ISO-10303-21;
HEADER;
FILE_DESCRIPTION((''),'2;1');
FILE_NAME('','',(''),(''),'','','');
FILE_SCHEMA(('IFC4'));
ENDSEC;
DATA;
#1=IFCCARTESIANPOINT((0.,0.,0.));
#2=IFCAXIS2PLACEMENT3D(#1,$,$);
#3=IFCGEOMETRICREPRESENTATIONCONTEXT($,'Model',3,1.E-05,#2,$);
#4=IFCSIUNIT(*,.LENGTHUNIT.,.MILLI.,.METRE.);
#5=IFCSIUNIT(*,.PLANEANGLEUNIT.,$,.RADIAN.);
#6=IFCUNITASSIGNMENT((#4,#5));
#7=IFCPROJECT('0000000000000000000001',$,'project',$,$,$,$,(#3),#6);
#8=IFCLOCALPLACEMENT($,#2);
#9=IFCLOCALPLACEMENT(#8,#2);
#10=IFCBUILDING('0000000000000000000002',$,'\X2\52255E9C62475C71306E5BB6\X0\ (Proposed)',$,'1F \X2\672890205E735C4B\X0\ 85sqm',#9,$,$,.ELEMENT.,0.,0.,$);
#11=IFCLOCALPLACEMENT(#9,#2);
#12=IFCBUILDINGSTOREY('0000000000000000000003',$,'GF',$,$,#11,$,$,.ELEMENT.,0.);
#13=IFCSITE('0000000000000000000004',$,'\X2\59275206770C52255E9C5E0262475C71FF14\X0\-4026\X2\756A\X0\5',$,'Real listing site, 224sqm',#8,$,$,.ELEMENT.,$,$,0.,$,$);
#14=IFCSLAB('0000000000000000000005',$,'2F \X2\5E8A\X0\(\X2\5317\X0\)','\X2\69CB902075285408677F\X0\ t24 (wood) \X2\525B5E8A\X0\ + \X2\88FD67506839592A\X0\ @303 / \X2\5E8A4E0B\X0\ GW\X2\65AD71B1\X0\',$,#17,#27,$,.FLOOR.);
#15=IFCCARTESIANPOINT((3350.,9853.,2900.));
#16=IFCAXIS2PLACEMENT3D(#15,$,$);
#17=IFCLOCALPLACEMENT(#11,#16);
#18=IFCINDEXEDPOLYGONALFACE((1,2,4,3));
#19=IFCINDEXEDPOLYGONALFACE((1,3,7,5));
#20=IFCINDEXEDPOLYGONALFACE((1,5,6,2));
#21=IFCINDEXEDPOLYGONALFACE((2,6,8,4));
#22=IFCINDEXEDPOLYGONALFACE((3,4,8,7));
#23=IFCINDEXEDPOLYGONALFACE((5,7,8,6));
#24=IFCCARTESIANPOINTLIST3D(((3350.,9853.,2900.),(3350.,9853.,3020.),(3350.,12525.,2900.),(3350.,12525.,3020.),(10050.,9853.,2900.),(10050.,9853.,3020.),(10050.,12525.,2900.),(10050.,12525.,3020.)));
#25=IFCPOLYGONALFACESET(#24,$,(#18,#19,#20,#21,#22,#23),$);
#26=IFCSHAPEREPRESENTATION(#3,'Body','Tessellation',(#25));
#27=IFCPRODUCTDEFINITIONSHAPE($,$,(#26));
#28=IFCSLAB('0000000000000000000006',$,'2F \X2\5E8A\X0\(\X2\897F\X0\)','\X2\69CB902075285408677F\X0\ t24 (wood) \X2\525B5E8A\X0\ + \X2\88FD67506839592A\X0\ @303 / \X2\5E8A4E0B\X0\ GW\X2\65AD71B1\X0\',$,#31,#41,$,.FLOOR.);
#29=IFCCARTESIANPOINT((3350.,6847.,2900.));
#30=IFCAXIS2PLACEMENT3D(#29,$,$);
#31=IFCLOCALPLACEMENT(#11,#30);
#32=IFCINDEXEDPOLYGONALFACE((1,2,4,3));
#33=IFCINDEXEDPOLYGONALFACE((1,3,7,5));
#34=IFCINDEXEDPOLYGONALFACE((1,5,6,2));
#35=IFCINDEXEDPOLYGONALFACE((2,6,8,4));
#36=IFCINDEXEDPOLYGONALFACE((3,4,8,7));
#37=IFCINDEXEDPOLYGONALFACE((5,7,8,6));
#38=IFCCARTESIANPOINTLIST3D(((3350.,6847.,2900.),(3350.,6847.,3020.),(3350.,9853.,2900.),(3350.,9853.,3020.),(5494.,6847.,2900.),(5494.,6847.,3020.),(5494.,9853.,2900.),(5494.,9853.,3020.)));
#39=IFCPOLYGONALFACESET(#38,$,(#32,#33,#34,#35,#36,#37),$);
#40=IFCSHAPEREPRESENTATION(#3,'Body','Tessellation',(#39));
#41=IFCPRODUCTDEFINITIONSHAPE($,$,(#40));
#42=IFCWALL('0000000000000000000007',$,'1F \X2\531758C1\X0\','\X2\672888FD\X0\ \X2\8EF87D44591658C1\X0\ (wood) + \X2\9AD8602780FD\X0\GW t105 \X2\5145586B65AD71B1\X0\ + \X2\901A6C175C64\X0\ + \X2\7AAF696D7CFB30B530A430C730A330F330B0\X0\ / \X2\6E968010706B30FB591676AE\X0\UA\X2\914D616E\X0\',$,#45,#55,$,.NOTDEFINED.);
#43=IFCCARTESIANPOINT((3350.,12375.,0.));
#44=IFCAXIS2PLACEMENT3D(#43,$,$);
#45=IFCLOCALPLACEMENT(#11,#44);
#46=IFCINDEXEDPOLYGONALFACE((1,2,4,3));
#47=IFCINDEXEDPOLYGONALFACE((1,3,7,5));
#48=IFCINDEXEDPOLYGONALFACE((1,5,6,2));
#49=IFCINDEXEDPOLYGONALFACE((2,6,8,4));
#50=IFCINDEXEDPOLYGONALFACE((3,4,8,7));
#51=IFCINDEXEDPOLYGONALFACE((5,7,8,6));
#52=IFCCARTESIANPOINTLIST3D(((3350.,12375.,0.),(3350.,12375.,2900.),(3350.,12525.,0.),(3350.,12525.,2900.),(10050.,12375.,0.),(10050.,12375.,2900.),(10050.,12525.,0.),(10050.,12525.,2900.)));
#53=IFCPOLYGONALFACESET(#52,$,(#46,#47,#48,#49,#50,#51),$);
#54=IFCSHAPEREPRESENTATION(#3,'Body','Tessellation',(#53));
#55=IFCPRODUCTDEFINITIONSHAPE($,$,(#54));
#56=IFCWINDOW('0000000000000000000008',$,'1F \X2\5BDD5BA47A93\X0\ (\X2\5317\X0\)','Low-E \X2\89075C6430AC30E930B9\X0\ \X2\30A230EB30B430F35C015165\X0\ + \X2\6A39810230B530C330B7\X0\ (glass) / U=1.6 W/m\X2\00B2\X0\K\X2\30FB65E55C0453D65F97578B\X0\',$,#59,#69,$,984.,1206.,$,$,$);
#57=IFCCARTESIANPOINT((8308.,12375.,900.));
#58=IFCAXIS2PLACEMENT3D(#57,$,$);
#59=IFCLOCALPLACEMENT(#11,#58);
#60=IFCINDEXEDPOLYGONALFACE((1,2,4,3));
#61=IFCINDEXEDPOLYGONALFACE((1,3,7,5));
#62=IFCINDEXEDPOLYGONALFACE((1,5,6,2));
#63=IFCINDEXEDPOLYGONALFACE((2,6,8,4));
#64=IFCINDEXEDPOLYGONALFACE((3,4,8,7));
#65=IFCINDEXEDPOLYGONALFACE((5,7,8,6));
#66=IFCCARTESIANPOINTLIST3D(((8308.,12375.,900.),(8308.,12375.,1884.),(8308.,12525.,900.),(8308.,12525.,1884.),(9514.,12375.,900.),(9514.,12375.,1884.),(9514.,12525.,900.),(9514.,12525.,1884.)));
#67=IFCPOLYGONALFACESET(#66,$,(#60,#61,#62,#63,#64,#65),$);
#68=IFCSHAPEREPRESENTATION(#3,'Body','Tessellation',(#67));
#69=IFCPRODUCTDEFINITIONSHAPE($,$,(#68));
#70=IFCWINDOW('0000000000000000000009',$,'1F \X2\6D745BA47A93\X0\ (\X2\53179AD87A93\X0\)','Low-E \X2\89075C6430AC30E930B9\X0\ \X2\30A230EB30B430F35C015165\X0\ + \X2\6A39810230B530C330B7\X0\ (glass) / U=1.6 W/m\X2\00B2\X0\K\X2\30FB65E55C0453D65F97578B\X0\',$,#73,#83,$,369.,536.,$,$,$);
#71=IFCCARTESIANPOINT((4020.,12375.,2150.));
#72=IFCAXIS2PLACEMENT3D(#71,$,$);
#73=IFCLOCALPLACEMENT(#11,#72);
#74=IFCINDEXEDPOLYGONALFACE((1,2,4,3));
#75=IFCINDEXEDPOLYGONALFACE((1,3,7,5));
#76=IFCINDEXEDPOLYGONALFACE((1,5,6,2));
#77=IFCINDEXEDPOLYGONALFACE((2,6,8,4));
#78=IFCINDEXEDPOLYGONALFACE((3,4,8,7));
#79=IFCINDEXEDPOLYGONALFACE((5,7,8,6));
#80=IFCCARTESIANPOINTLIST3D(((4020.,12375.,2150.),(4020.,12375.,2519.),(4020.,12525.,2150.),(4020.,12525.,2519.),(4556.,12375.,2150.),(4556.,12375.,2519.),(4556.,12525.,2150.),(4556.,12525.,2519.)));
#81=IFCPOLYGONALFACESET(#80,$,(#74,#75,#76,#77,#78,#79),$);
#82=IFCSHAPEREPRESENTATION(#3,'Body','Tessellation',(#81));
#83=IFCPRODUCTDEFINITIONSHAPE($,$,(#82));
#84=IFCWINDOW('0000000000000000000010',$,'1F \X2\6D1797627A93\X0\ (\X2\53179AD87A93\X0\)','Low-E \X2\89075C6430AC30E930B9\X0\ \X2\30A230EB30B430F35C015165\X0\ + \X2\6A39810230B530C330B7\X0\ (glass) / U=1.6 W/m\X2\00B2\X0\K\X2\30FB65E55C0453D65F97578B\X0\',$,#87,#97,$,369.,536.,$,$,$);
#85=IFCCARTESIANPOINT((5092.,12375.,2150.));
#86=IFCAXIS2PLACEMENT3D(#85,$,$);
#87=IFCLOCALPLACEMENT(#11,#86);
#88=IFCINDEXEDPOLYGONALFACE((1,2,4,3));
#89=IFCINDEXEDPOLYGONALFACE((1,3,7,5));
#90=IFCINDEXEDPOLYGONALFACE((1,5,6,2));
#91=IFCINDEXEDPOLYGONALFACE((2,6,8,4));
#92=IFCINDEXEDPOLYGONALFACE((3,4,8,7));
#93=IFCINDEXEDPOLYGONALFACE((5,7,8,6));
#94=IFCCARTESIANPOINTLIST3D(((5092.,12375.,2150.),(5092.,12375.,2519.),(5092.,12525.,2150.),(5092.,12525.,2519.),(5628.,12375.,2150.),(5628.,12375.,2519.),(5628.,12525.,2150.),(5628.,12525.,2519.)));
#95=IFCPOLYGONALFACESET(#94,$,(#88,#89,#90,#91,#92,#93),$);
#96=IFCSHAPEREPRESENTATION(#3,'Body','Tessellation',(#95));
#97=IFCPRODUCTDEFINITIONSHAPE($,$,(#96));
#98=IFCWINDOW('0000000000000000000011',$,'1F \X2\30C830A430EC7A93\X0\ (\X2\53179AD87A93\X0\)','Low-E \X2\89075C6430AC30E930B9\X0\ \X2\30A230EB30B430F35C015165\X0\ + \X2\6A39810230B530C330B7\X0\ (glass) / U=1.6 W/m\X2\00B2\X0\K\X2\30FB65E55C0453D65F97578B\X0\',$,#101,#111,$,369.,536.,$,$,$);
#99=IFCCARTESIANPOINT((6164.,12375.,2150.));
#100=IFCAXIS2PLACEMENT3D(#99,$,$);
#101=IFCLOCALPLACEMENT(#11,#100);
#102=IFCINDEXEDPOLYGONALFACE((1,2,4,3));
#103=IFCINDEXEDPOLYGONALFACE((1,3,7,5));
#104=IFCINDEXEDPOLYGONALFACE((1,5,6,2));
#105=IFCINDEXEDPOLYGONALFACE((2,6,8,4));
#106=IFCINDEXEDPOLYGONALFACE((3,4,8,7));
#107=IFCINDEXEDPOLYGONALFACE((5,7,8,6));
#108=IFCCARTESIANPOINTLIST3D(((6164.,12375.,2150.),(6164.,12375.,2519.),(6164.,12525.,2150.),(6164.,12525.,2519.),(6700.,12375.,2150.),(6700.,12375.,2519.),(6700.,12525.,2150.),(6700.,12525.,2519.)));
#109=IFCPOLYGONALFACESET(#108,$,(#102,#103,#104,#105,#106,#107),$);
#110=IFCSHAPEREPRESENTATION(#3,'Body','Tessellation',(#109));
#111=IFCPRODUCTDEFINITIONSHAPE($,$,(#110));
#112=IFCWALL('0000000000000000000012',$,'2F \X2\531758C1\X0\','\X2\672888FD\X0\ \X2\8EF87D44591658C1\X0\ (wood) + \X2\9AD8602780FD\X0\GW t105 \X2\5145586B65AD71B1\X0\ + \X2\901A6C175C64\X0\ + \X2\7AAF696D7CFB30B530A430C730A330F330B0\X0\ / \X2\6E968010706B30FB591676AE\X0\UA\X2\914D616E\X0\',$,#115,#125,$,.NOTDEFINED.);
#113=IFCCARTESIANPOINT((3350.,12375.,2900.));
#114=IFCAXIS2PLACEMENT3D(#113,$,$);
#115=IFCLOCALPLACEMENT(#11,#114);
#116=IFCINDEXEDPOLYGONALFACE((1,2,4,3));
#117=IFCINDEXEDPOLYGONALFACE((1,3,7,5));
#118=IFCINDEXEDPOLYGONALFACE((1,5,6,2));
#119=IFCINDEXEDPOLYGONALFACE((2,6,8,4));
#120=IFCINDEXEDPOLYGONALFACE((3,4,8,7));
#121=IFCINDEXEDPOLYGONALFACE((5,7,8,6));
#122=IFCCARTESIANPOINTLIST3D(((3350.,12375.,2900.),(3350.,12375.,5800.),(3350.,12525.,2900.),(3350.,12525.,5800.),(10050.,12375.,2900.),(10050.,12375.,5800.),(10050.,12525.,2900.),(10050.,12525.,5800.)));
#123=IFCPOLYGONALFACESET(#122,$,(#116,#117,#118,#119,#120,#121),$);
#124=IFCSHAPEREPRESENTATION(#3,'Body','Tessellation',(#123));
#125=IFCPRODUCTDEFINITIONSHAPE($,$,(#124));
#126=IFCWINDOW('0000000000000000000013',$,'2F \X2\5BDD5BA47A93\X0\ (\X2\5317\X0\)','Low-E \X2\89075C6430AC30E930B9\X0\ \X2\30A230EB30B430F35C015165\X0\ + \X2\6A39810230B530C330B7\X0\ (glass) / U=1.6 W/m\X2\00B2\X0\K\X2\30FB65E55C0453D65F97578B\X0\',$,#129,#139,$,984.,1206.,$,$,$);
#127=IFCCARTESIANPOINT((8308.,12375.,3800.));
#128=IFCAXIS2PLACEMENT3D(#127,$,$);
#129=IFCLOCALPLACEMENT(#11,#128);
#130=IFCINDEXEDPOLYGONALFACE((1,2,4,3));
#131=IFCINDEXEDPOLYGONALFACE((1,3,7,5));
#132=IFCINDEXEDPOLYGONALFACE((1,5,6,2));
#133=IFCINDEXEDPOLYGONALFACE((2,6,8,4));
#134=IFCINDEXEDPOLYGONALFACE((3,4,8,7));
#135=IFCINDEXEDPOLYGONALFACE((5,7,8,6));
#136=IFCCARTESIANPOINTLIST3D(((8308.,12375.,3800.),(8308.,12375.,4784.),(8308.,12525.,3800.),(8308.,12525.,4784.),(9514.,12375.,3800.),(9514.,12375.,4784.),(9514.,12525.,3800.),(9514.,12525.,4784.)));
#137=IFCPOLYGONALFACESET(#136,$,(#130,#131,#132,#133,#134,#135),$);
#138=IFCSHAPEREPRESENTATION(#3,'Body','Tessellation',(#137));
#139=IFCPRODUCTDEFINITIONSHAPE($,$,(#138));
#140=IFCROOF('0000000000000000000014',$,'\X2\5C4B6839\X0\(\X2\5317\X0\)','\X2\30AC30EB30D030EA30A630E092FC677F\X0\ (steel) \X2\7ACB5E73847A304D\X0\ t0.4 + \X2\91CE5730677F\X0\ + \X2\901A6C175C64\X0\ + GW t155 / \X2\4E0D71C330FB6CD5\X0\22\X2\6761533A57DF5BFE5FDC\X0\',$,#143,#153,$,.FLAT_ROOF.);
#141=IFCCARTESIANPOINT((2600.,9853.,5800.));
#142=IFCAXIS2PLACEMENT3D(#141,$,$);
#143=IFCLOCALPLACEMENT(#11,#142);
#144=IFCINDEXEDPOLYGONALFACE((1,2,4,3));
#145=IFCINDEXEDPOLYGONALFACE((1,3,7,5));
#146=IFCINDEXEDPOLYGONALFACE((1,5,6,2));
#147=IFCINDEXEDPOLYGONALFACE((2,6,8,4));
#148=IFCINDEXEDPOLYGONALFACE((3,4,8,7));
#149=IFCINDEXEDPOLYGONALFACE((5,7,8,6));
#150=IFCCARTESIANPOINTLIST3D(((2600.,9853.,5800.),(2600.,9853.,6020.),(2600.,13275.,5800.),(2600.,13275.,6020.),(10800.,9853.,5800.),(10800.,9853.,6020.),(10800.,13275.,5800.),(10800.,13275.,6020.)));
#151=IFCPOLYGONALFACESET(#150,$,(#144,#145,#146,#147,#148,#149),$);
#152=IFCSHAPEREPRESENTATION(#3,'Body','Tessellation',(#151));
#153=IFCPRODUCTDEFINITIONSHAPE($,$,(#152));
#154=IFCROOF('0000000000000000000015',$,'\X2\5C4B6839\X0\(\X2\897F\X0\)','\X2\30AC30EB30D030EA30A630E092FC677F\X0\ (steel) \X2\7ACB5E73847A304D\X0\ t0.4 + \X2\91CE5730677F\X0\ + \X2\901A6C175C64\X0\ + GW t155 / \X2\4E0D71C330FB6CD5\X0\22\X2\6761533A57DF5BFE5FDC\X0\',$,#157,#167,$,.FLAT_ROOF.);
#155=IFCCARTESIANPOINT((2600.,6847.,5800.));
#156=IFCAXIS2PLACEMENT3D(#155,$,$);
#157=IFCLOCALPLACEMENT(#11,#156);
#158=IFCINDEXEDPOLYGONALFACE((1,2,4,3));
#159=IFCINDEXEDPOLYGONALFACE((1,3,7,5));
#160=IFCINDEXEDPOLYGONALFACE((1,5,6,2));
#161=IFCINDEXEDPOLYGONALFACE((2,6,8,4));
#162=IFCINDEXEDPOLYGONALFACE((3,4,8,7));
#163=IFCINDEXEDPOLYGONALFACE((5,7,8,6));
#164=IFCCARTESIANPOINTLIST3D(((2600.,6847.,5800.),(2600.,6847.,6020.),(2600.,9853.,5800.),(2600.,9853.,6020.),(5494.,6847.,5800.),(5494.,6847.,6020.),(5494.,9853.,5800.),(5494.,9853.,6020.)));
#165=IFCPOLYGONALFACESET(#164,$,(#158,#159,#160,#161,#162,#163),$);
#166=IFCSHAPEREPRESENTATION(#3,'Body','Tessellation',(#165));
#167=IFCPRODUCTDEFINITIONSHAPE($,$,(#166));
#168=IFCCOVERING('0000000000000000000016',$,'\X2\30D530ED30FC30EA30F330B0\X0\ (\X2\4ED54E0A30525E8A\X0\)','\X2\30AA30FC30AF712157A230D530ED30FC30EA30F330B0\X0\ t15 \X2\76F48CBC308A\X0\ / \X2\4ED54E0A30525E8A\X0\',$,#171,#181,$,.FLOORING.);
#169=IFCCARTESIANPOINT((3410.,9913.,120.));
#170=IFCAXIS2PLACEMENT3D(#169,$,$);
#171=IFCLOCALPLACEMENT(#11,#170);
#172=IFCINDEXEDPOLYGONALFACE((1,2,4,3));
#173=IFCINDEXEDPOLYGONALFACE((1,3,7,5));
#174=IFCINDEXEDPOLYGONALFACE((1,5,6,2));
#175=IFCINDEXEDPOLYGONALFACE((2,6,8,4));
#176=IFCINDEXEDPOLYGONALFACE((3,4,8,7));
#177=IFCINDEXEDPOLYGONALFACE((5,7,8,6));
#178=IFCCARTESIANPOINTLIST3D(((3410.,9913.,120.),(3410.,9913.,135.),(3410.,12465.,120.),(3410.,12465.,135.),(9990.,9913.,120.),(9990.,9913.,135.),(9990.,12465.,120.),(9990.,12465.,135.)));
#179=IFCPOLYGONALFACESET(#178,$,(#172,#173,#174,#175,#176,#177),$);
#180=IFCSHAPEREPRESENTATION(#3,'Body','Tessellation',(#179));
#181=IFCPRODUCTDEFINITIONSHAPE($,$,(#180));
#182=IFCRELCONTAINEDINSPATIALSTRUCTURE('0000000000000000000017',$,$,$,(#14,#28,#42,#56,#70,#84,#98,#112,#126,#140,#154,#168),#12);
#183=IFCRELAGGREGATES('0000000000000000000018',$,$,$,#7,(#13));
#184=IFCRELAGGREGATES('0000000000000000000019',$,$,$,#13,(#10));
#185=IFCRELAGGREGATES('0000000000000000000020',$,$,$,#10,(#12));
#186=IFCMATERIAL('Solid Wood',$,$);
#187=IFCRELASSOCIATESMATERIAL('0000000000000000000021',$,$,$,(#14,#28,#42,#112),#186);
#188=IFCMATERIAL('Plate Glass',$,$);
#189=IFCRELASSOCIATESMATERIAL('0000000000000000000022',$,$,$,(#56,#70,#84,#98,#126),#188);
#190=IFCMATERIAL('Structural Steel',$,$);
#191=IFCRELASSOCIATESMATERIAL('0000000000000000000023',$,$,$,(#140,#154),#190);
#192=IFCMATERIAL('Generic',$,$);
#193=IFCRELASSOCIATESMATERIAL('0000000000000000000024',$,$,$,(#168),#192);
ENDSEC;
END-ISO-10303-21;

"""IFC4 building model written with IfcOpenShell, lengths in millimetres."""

from ifc_helpers import new_model, si_unit, frame, frame_2d, origin, place, context, project, spatial, rectangle, extrude, material, element, fill, save


model = new_model("IFC4")

# Units and contexts
model_context = context("Model", 3, precision=1e-05, world=origin())
ifc_project = project(units=[si_unit("LENGTHUNIT", "METRE", prefix="MILLI"), si_unit("PLANEANGLEUNIT", "RADIAN")], contexts=[model_context])

# Site, building, storey
site_placement = place(None, origin())
site = spatial("IfcSite", under=ifc_project, at=site_placement, Name="大分県別府市扇山４-4026番5", ObjectType="Real listing site, 224sqm", CompositionType="ELEMENT", RefElevation=0.0)
building_placement = place(site_placement, origin())
building = spatial("IfcBuilding", under=site, at=building_placement, Name="別府扇山の家 (Proposed)", ObjectType="1F 木造平屋 85sqm", CompositionType="ELEMENT", ElevationOfRefHeight=0.0, ElevationOfTerrain=0.0)
storey_placement = place(building_placement, origin())
storey = spatial("IfcBuildingStorey", under=building, at=storey_placement, Name="GF", CompositionType="ELEMENT", Elevation=0.0)

# Slabs
ifc_material_1 = material(Name="Solid Wood")
slab_1_placement = place(storey_placement, frame((3350.0, 9853.0, 2900.0)))
element("IfcSlab", 1, at=slab_1_placement, inside=storey, material=ifc_material_1, Name="2F 床(北)", Description="構造用合板 t24 (wood) 剛床 + 製材根太 @303 / 床下 GW断熱", PredefinedType="FLOOR", context=model_context, shape_type="SweptSolid", body=[
    extrude(rectangle(XDim=6700.0, YDim=2672.0, at=frame_2d((3350.0, 1336.0))), frame((3350.0, 9853.0, 2900.0)), (0.0, 0.0, 1.0), 120.0),
])
slab_2_placement = place(storey_placement, frame((3350.0, 6847.0, 2900.0)))
element("IfcSlab", 2, at=slab_2_placement, inside=storey, material=ifc_material_1, Name="2F 床(西)", Description="構造用合板 t24 (wood) 剛床 + 製材根太 @303 / 床下 GW断熱", PredefinedType="FLOOR", context=model_context, shape_type="SweptSolid", body=[
    extrude(rectangle(XDim=2144.0, YDim=3006.0, at=frame_2d((1072.0, 1503.0))), frame((3350.0, 6847.0, 2900.0)), (0.0, 0.0, 1.0), 120.0),
])

# Wall, openings, windows
wall_1_placement = place(storey_placement, frame((3350.0, 12375.0, 0.0)))
wall_1 = element("IfcWall", 3, at=wall_1_placement, inside=storey, material=ifc_material_1, Name="1F 北壁", Description="木製 軸組外壁 (wood) + 高性能GW t105 充填断熱 + 通気層 + 窯業系サイディング / 準耐火・外皮UA配慮", PredefinedType="NOTDEFINED", context=model_context, shape_type="SweptSolid", body=[
    extrude(rectangle(XDim=6700.0, YDim=150.0, at=frame_2d((3350.0, 75.0))), frame((3350.0, 12375.0, 0.0)), (0.0, 0.0, 1.0), 2900.0),
])
opening_1_placement = place(storey_placement, frame((8308.0, 12375.0, 900.0)))
opening_1 = element("IfcOpeningElement", 4, at=opening_1_placement, cuts=wall_1, PredefinedType="NOTDEFINED", context=model_context, shape_type="SweptSolid", body=[
    extrude(rectangle(XDim=1206.0, YDim=150.0, at=frame_2d((603.0, 75.0))), frame((8308.0, 12375.0, 900.0)), (0.0, 0.0, 1.0), 984.0),
])
opening_2_placement = place(storey_placement, frame((4020.0, 12375.0, 2150.0)))
opening_2 = element("IfcOpeningElement", 5, at=opening_2_placement, cuts=wall_1, PredefinedType="NOTDEFINED", context=model_context, shape_type="SweptSolid", body=[
    extrude(rectangle(XDim=536.0, YDim=150.0, at=frame_2d((268.0, 75.0))), frame((4020.0, 12375.0, 2150.0)), (0.0, 0.0, 1.0), 369.0),
])
opening_3_placement = place(storey_placement, frame((5092.0, 12375.0, 2150.0)))
opening_3 = element("IfcOpeningElement", 6, at=opening_3_placement, cuts=wall_1, PredefinedType="NOTDEFINED", context=model_context, shape_type="SweptSolid", body=[
    extrude(rectangle(XDim=536.0, YDim=150.0, at=frame_2d((268.0, 75.0))), frame((5092.0, 12375.0, 2150.0)), (0.0, 0.0, 1.0), 369.0),
])
opening_4_placement = place(storey_placement, frame((6164.0, 12375.0, 2150.0)))
opening_4 = element("IfcOpeningElement", 7, at=opening_4_placement, cuts=wall_1, PredefinedType="NOTDEFINED", context=model_context, shape_type="SweptSolid", body=[
    extrude(rectangle(XDim=536.0, YDim=150.0, at=frame_2d((268.0, 75.0))), frame((6164.0, 12375.0, 2150.0)), (0.0, 0.0, 1.0), 369.0),
])
ifc_material_2 = material(Name="Plate Glass")
window_1_placement = place(storey_placement, frame((8308.0, 12375.0, 900.0)))
window_1 = element("IfcWindow", 8, at=window_1_placement, inside=storey, material=ifc_material_2, Name="1F 寝室窓 (北)", Description="Low-E 複層ガラス アルゴン封入 + 樹脂サッシ (glass) / U=1.6 W/m²K・日射取得型", OverallHeight=984.0, OverallWidth=1206.0, context=model_context, shape_type="SweptSolid", body=[
    extrude(rectangle(XDim=1206.0, YDim=150.0, at=frame_2d((603.0, 75.0))), frame((8308.0, 12375.0, 900.0)), (0.0, 0.0, 1.0), 984.0),
])
fill(opening_1, window_1)
window_2_placement = place(storey_placement, frame((4020.0, 12375.0, 2150.0)))
window_2 = element("IfcWindow", 9, at=window_2_placement, inside=storey, material=ifc_material_2, Name="1F 浴室窓 (北高窓)", Description="Low-E 複層ガラス アルゴン封入 + 樹脂サッシ (glass) / U=1.6 W/m²K・日射取得型", OverallHeight=369.0, OverallWidth=536.0, context=model_context, shape_type="SweptSolid", body=[
    extrude(rectangle(XDim=536.0, YDim=150.0, at=frame_2d((268.0, 75.0))), frame((4020.0, 12375.0, 2150.0)), (0.0, 0.0, 1.0), 369.0),
])
fill(opening_2, window_2)
window_3_placement = place(storey_placement, frame((5092.0, 12375.0, 2150.0)))
window_3 = element("IfcWindow", 10, at=window_3_placement, inside=storey, material=ifc_material_2, Name="1F 洗面窓 (北高窓)", Description="Low-E 複層ガラス アルゴン封入 + 樹脂サッシ (glass) / U=1.6 W/m²K・日射取得型", OverallHeight=369.0, OverallWidth=536.0, context=model_context, shape_type="SweptSolid", body=[
    extrude(rectangle(XDim=536.0, YDim=150.0, at=frame_2d((268.0, 75.0))), frame((5092.0, 12375.0, 2150.0)), (0.0, 0.0, 1.0), 369.0),
])
fill(opening_3, window_3)
window_4_placement = place(storey_placement, frame((6164.0, 12375.0, 2150.0)))
window_4 = element("IfcWindow", 11, at=window_4_placement, inside=storey, material=ifc_material_2, Name="1F トイレ窓 (北高窓)", Description="Low-E 複層ガラス アルゴン封入 + 樹脂サッシ (glass) / U=1.6 W/m²K・日射取得型", OverallHeight=369.0, OverallWidth=536.0, context=model_context, shape_type="SweptSolid", body=[
    extrude(rectangle(XDim=536.0, YDim=150.0, at=frame_2d((268.0, 75.0))), frame((6164.0, 12375.0, 2150.0)), (0.0, 0.0, 1.0), 369.0),
])
fill(opening_4, window_4)

# Wall, opening, window
wall_2_placement = place(storey_placement, frame((3350.0, 12375.0, 2900.0)))
wall_2 = element("IfcWall", 12, at=wall_2_placement, inside=storey, material=ifc_material_1, Name="2F 北壁", Description="木製 軸組外壁 (wood) + 高性能GW t105 充填断熱 + 通気層 + 窯業系サイディング / 準耐火・外皮UA配慮", PredefinedType="NOTDEFINED", context=model_context, shape_type="SweptSolid", body=[
    extrude(rectangle(XDim=6700.0, YDim=150.0, at=frame_2d((3350.0, 75.0))), frame((3350.0, 12375.0, 2900.0)), (0.0, 0.0, 1.0), 2900.0),
])
opening_5_placement = place(storey_placement, frame((8308.0, 12375.0, 3800.0)))
opening_5 = element("IfcOpeningElement", 13, at=opening_5_placement, cuts=wall_2, PredefinedType="NOTDEFINED", context=model_context, shape_type="SweptSolid", body=[
    extrude(rectangle(XDim=1206.0, YDim=150.0, at=frame_2d((603.0, 75.0))), frame((8308.0, 12375.0, 3800.0)), (0.0, 0.0, 1.0), 984.0),
])
window_5_placement = place(storey_placement, frame((8308.0, 12375.0, 3800.0)))
window_5 = element("IfcWindow", 14, at=window_5_placement, inside=storey, material=ifc_material_2, Name="2F 寝室窓 (北)", Description="Low-E 複層ガラス アルゴン封入 + 樹脂サッシ (glass) / U=1.6 W/m²K・日射取得型", OverallHeight=984.0, OverallWidth=1206.0, context=model_context, shape_type="SweptSolid", body=[
    extrude(rectangle(XDim=1206.0, YDim=150.0, at=frame_2d((603.0, 75.0))), frame((8308.0, 12375.0, 3800.0)), (0.0, 0.0, 1.0), 984.0),
])
fill(opening_5, window_5)

# Roofs
ifc_material_3 = material(Name="Structural Steel")
for number, where, name in (
    (15, (2600.0, 9853.0, 5800.0), "屋根(北)"),
):
    element("IfcRoof", number, at=place(storey_placement, frame(where)), inside=storey, material=ifc_material_3, Name=name, Description="ガルバリウム鋼板 (steel) 立平葺き t0.4 + 野地板 + 通気層 + GW t155 / 不燃・法22条区域対応", PredefinedType="FLAT_ROOF", context=model_context, shape_type="SweptSolid", body=[
        extrude(rectangle(XDim=8200.0, YDim=3422.0, at=frame_2d((4100.0, 1711.0))), frame((2600.0, 9853.0, 5800.0)), (0.0, 0.0, 1.0), 220.0),
    ])
roof_placement = place(storey_placement, frame((2600.0, 6847.0, 5800.0)))
element("IfcRoof", 16, at=roof_placement, inside=storey, material=ifc_material_3, Name="屋根(西)", Description="ガルバリウム鋼板 (steel) 立平葺き t0.4 + 野地板 + 通気層 + GW t155 / 不燃・法22条区域対応", PredefinedType="FLAT_ROOF", context=model_context, shape_type="SweptSolid", body=[
    extrude(rectangle(XDim=2894.0, YDim=3006.0, at=frame_2d((1447.0, 1503.0))), frame((2600.0, 6847.0, 5800.0)), (0.0, 0.0, 1.0), 220.0),
])

# Covering
ifc_material_4 = material(Name="Generic")
covering_1_placement = place(storey_placement, frame((3410.0, 9913.0, 120.0)))
element("IfcCovering", 17, at=covering_1_placement, inside=storey, material=ifc_material_4, Name="フローリング (仕上げ床)", Description="オーク無垢フローリング t15 直貼り / 仕上げ床", PredefinedType="FLOORING", context=model_context, shape_type="SweptSolid", body=[
    extrude(rectangle(XDim=6580.0, YDim=2552.0, at=frame_2d((3290.0, 1276.0))), frame((3410.0, 9913.0, 120.0)), (0.0, 0.0, 1.0), 15.0),
])

save(model, "model.ifc")
